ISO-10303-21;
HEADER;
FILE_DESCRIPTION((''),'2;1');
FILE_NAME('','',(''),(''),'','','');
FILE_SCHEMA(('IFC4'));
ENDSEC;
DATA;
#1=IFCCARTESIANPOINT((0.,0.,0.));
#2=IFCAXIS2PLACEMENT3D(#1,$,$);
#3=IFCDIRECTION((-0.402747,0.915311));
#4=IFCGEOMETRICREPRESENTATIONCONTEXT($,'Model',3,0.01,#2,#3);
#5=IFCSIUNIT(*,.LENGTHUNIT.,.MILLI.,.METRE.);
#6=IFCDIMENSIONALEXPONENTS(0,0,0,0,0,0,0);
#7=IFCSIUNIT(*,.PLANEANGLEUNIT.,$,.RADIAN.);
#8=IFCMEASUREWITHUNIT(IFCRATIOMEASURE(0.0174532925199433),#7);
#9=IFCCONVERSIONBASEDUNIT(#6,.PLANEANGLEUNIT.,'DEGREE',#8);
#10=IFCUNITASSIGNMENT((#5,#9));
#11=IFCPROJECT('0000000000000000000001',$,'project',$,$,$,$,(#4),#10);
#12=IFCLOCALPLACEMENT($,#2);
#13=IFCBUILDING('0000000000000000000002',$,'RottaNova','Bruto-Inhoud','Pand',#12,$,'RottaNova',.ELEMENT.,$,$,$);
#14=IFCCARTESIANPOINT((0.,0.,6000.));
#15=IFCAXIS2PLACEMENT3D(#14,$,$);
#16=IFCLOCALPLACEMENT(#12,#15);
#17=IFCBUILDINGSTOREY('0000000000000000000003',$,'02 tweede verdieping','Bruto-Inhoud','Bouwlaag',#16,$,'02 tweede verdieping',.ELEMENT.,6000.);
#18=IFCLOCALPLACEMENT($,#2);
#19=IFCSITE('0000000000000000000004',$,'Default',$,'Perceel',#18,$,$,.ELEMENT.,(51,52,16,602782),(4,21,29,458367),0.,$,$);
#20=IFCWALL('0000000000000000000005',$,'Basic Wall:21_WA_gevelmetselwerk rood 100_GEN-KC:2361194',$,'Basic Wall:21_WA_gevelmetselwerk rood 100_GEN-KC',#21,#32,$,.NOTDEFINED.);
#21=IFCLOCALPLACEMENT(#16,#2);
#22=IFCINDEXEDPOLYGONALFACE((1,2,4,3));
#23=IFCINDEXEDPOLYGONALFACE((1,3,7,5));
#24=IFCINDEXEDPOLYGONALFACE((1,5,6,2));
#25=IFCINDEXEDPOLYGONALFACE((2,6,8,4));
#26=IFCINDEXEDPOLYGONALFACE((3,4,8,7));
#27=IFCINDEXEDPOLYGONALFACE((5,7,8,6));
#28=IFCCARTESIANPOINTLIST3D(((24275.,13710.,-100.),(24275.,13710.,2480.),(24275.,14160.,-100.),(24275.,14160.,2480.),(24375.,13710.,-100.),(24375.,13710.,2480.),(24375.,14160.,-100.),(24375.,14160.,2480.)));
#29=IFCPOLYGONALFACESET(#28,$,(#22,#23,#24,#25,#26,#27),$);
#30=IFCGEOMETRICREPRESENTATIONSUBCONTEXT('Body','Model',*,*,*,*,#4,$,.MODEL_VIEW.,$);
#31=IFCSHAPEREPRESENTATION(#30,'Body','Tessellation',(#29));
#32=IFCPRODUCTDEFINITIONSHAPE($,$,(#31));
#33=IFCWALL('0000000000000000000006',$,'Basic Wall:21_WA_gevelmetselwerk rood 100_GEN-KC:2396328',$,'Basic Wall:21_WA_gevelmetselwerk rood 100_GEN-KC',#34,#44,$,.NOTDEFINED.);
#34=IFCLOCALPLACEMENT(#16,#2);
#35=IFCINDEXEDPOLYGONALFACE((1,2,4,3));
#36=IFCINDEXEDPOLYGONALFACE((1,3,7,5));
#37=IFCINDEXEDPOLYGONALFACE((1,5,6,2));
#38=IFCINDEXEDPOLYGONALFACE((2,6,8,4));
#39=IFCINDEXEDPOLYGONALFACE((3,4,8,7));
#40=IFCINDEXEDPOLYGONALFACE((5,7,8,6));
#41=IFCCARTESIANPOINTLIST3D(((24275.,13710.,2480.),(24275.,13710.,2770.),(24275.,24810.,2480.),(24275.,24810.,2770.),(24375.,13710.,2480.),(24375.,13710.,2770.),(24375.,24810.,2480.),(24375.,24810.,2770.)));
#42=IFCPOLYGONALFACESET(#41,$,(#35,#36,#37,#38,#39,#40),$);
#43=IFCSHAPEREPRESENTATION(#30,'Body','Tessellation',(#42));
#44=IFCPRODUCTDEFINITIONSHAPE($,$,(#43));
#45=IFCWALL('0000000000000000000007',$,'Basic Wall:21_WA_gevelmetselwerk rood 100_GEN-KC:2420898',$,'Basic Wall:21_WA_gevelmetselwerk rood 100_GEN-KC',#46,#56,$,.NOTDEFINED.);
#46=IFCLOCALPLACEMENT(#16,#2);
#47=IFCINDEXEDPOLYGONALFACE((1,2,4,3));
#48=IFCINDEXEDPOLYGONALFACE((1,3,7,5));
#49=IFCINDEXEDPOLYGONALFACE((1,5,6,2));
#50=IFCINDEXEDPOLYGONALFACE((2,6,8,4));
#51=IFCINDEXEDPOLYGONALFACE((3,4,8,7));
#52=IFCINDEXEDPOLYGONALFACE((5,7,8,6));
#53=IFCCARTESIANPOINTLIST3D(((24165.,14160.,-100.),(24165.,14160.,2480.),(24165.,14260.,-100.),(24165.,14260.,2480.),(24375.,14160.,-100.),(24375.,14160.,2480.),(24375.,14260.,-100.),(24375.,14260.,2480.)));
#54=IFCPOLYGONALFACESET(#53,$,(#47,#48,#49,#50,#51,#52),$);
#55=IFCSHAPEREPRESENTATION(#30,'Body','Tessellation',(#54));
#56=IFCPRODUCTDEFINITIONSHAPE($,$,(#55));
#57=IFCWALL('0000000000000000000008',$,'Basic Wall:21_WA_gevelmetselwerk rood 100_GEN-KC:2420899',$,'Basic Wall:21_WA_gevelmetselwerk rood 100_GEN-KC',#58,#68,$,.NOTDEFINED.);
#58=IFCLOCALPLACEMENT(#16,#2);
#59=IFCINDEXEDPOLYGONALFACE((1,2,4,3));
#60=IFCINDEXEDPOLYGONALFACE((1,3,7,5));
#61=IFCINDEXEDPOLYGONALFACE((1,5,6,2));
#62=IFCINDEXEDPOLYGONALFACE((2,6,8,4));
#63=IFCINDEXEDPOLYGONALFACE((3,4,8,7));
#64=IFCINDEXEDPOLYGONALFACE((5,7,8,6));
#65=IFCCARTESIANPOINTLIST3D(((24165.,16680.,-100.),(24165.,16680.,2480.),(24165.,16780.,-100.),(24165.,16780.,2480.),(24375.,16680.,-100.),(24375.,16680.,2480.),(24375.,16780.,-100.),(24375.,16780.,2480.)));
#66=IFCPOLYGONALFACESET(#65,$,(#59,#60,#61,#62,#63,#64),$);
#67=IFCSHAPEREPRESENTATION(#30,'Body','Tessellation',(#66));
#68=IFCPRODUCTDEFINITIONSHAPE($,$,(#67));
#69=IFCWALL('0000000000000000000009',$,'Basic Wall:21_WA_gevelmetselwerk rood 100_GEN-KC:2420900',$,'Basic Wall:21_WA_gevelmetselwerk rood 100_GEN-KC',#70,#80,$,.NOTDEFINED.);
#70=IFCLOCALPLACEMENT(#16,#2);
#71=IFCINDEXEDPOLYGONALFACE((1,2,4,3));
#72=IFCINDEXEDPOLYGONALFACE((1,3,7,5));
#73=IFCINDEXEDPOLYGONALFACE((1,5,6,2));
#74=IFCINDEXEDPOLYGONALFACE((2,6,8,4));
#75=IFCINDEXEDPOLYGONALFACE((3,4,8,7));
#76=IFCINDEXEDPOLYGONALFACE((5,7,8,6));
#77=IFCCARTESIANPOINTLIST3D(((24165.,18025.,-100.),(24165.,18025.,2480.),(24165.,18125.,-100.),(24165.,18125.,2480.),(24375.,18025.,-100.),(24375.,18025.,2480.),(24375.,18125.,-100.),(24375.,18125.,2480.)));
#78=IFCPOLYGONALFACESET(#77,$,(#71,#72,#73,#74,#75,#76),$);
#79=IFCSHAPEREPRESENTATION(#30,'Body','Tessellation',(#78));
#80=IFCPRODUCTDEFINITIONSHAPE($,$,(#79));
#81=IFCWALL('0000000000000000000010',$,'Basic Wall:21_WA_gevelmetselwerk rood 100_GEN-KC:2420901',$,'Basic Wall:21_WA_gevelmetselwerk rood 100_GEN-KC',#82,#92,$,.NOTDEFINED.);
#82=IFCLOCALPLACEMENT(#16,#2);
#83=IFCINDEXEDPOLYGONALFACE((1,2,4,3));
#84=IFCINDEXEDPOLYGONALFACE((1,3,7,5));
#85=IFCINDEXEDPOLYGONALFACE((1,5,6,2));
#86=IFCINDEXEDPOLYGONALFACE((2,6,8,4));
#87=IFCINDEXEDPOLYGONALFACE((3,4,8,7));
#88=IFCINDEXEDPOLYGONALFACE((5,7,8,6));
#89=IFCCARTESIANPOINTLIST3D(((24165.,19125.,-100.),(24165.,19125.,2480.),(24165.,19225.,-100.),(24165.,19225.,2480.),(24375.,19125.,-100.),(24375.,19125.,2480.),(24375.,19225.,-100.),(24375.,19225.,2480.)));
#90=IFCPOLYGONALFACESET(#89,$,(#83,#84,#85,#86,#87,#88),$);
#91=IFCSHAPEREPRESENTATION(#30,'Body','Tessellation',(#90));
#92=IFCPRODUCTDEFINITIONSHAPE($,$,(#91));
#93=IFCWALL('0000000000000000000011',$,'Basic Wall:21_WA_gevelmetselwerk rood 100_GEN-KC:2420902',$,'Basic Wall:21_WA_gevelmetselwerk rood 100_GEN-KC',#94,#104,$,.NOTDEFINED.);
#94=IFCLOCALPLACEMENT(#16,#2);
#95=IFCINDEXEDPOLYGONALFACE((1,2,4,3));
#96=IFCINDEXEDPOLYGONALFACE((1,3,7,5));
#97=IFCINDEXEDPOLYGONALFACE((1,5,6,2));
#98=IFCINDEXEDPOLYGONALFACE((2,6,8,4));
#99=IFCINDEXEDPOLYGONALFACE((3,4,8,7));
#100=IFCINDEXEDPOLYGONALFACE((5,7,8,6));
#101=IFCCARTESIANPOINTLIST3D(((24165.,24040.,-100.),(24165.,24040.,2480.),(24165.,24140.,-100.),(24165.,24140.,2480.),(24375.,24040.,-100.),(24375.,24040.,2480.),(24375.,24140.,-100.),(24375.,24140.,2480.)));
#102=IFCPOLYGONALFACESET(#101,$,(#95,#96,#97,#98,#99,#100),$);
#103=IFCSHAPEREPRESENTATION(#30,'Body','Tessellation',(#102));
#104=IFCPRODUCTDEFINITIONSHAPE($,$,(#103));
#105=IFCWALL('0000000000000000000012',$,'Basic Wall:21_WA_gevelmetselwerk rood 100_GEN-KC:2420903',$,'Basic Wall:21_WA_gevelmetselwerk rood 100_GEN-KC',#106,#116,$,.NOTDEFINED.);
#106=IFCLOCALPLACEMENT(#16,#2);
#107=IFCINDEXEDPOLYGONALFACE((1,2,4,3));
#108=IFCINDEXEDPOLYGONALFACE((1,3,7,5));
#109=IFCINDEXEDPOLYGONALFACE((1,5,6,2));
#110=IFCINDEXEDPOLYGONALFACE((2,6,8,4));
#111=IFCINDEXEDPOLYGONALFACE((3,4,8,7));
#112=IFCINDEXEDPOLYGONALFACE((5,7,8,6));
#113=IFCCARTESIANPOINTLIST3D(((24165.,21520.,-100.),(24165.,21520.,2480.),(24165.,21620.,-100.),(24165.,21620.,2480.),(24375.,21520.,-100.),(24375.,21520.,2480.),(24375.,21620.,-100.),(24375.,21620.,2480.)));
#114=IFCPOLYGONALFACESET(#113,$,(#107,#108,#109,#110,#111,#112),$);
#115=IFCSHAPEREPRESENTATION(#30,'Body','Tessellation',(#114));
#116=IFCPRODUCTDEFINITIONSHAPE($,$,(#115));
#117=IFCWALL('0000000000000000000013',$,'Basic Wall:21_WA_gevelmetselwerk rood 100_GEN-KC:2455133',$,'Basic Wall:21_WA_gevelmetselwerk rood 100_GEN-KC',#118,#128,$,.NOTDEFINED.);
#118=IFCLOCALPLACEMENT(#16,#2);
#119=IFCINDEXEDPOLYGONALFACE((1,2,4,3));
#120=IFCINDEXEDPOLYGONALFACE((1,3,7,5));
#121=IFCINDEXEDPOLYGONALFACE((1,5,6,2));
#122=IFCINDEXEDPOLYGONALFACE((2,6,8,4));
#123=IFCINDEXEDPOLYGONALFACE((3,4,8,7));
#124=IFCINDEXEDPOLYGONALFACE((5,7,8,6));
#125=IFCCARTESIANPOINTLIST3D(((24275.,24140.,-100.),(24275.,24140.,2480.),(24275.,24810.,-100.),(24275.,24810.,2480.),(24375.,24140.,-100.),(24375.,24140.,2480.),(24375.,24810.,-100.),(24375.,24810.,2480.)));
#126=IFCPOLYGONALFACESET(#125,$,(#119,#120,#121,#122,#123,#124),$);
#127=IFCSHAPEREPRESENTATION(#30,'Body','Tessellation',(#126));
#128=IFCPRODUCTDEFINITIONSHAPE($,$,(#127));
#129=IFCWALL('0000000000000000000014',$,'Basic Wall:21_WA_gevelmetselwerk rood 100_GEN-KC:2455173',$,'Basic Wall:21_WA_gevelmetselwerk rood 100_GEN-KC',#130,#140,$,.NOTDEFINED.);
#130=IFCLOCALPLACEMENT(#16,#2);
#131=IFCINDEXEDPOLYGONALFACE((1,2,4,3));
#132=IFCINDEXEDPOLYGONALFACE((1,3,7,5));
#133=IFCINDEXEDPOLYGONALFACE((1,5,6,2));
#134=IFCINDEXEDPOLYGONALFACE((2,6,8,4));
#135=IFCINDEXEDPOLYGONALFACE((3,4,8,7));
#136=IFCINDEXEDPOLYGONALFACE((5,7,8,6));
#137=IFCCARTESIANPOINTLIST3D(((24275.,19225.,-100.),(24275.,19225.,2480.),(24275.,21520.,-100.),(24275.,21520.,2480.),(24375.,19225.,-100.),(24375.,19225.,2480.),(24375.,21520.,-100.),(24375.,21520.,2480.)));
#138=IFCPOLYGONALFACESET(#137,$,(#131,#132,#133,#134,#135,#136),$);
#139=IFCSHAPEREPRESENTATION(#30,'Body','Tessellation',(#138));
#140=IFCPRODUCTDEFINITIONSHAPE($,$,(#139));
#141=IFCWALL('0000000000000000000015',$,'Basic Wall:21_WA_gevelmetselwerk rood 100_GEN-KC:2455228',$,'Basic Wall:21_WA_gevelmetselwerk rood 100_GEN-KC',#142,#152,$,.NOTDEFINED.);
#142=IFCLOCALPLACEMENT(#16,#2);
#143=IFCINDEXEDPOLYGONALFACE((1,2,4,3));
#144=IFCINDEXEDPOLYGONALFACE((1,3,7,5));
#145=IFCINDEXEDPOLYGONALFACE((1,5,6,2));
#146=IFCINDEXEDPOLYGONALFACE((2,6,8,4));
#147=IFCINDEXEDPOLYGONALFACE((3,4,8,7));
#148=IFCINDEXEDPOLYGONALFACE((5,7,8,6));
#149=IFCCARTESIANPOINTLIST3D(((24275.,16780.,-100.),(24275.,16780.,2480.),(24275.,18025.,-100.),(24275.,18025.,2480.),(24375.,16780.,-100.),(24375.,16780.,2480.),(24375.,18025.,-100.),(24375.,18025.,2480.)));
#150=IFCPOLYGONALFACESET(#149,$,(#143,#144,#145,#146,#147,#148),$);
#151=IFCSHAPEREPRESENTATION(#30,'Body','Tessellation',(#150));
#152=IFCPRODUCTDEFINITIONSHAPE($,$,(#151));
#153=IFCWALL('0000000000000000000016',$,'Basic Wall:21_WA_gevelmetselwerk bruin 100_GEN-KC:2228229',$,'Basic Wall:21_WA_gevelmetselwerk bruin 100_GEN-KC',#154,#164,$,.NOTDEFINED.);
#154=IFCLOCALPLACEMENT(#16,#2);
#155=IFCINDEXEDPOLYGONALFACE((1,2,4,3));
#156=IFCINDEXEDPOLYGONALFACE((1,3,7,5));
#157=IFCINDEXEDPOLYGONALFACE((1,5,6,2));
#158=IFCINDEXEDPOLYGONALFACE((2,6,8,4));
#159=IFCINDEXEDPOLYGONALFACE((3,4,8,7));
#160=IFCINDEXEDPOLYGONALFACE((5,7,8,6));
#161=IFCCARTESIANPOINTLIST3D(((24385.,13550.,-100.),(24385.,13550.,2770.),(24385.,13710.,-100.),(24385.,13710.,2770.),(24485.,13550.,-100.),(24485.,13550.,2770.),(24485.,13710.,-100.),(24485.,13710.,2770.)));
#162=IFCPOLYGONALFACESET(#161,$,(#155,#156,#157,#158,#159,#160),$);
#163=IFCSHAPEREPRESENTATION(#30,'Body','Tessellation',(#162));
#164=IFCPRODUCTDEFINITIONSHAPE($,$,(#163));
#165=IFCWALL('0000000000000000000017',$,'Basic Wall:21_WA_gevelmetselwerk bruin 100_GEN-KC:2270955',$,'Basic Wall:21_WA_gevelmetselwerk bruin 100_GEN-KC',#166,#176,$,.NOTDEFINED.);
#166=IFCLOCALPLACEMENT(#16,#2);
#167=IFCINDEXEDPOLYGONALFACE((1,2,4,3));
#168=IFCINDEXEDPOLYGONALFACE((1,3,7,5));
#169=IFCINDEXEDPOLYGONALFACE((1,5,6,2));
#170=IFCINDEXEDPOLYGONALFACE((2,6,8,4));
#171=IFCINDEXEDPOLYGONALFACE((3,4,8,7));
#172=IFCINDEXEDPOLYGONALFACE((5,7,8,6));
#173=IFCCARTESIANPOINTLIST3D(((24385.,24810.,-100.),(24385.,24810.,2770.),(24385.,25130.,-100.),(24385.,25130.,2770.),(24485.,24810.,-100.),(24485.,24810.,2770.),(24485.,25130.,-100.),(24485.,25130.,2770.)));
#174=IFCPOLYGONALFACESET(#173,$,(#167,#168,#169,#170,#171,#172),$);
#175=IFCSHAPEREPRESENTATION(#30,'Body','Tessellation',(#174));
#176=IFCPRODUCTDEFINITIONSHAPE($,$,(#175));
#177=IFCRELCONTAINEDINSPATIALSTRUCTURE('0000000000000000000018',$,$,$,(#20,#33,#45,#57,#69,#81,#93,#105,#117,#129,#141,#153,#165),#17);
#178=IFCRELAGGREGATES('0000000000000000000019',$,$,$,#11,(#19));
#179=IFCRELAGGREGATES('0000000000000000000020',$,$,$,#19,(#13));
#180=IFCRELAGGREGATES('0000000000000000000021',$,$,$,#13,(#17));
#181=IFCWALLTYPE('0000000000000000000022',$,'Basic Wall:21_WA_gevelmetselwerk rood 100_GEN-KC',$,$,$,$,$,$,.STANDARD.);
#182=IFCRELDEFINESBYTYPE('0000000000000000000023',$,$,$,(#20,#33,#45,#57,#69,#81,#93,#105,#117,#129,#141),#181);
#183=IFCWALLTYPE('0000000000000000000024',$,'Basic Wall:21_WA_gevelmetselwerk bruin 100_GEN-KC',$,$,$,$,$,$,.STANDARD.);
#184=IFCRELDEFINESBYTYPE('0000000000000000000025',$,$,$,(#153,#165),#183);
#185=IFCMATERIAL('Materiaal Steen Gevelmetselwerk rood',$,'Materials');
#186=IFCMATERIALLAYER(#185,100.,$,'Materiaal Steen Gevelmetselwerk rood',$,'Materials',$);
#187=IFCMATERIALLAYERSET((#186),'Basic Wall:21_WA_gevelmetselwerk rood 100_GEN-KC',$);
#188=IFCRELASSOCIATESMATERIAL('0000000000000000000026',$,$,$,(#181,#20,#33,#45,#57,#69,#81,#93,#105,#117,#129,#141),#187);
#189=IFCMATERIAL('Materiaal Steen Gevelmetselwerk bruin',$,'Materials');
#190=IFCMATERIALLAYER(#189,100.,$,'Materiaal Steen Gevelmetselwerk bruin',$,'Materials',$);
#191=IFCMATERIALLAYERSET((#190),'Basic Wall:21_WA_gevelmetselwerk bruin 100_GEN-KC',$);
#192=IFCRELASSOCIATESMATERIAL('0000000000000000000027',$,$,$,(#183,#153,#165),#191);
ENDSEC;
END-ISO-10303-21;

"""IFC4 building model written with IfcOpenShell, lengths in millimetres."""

from ifc_helpers import new_model, entity, si_unit, converted_unit, direction, frame, frame_2d, origin, place, context, subcontext, project, spatial, rectangle, extrude, material, layer, layer_set, type_object, element, save


model = new_model("IFC4")

# Units and contexts
model_context = context("Model", 3, precision=0.01, world=origin(), true_north=direction((-0.402747, 0.915311)))
body_context = subcontext(model_context, "Body", "Model", "MODEL_VIEW")
ifc_project = project(units=[si_unit("LENGTHUNIT", "METRE", prefix="MILLI"), converted_unit("PLANEANGLEUNIT", "DEGREE", entity("IfcRatioMeasure", 0.0174532925199433), si_unit("PLANEANGLEUNIT", "RADIAN"), dimensions=[0, 0, 0, 0, 0, 0, 0])], contexts=[model_context])

# Site, building, storey
site_placement = place(None, origin())
site = spatial("IfcSite", under=ifc_project, at=site_placement, Name="Default", ObjectType="Perceel", CompositionType="ELEMENT", RefLatitude=(51, 52, 16, 602782), RefLongitude=(4, 21, 29, 458367), RefElevation=0.0)
building_placement = place(None, origin())
building = spatial("IfcBuilding", under=site, at=building_placement, Name="RottaNova", Description="Bruto-Inhoud", ObjectType="Pand", LongName="RottaNova", CompositionType="ELEMENT")
storey_placement = place(building_placement, frame((0.0, 0.0, 6000.0)))
storey = spatial("IfcBuildingStorey", under=building, at=storey_placement, Name="02 tweede verdieping", Description="Bruto-Inhoud", ObjectType="Bouwlaag", LongName="02 tweede verdieping", CompositionType="ELEMENT", Elevation=6000.0)

# Walls
ifc_material_1 = material(Name="Materiaal Steen Gevelmetselwerk rood", Category="Materials")
ifc_layer_1 = layer(ifc_material_1, 100.0, Name="Materiaal Steen Gevelmetselwerk rood", Category="Materials")
ifc_layer_set_1 = layer_set([ifc_layer_1], Name="Basic Wall:21_WA_gevelmetselwerk rood 100_GEN-KC")
wall_type_1 = type_object("IfcWallType", Name="Basic Wall:21_WA_gevelmetselwerk rood 100_GEN-KC", PredefinedType="STANDARD", material=ifc_layer_set_1)
wall_1_placement = place(storey_placement, frame((24325.0, 13710.0, -100.0), z_axis=(0.0, 0.0, 1.0), x_axis=(0.0, 1.0, 0.0)))
element("IfcWall", 1, at=wall_1_placement, inside=storey, type_object=wall_type_1, material=ifc_layer_set_1, Name="Basic Wall:21_WA_gevelmetselwerk rood 100_GEN-KC:2361194", ObjectType="Basic Wall:21_WA_gevelmetselwerk rood 100_GEN-KC", PredefinedType="NOTDEFINED", context=body_context, shape_type="SweptSolid", body=[
    extrude(rectangle(XDim=450.0, YDim=100.0, at=frame_2d((225.0, 0.0), x_axis=(-1.0, 0.0))), origin(), (0.0, 0.0, 1.0), 2580.0),
])
wall_2_placement = place(storey_placement, frame((24325.0, 13710.0, 2480.0), z_axis=(0.0, 0.0, 1.0), x_axis=(0.0, 1.0, 0.0)))
element("IfcWall", 2, at=wall_2_placement, inside=storey, type_object=wall_type_1, material=ifc_layer_set_1, Name="Basic Wall:21_WA_gevelmetselwerk rood 100_GEN-KC:2396328", ObjectType="Basic Wall:21_WA_gevelmetselwerk rood 100_GEN-KC", PredefinedType="NOTDEFINED", context=body_context, shape_type="SweptSolid", body=[
    extrude(rectangle(XDim=11100.0, YDim=100.0, at=frame_2d((5550.0, 0.0), x_axis=(-1.0, 0.0))), origin(), (0.0, 0.0, 1.0), 290.0),
])
wall_3_placement = place(storey_placement, frame((24375.0, 14210.0, -100.0), z_axis=(0.0, 0.0, 1.0), x_axis=(-1.0, 0.0, 0.0)))
element("IfcWall", 3, at=wall_3_placement, inside=storey, type_object=wall_type_1, material=ifc_layer_set_1, Name="Basic Wall:21_WA_gevelmetselwerk rood 100_GEN-KC:2420898", ObjectType="Basic Wall:21_WA_gevelmetselwerk rood 100_GEN-KC", PredefinedType="NOTDEFINED", context=body_context, shape_type="SweptSolid", body=[
    extrude(rectangle(XDim=210.0, YDim=100.0, at=frame_2d((105.0, 0.0), x_axis=(-1.0, 0.0))), origin(), (0.0, 0.0, 1.0), 2580.0),
])
wall_4_placement = place(storey_placement, frame((24375.0, 16730.0, -100.0), z_axis=(0.0, 0.0, 1.0), x_axis=(-1.0, 0.0, 0.0)))
element("IfcWall", 4, at=wall_4_placement, inside=storey, type_object=wall_type_1, material=ifc_layer_set_1, Name="Basic Wall:21_WA_gevelmetselwerk rood 100_GEN-KC:2420899", ObjectType="Basic Wall:21_WA_gevelmetselwerk rood 100_GEN-KC", PredefinedType="NOTDEFINED", context=body_context, shape_type="SweptSolid", body=[
    extrude(rectangle(XDim=210.0, YDim=100.0, at=frame_2d((105.0, 0.0), x_axis=(-1.0, 0.0))), origin(), (0.0, 0.0, 1.0), 2580.0),
])
wall_5_placement = place(storey_placement, frame((24375.0, 18075.0, -100.0), z_axis=(0.0, 0.0, 1.0), x_axis=(-1.0, 0.0, 0.0)))
element("IfcWall", 5, at=wall_5_placement, inside=storey, type_object=wall_type_1, material=ifc_layer_set_1, Name="Basic Wall:21_WA_gevelmetselwerk rood 100_GEN-KC:2420900", ObjectType="Basic Wall:21_WA_gevelmetselwerk rood 100_GEN-KC", PredefinedType="NOTDEFINED", context=body_context, shape_type="SweptSolid", body=[
    extrude(rectangle(XDim=210.0, YDim=100.0, at=frame_2d((105.0, 0.0), x_axis=(-1.0, 0.0))), origin(), (0.0, 0.0, 1.0), 2580.0),
])
wall_6_placement = place(storey_placement, frame((24375.0, 19175.0, -100.0), z_axis=(0.0, 0.0, 1.0), x_axis=(-1.0, 0.0, 0.0)))
element("IfcWall", 6, at=wall_6_placement, inside=storey, type_object=wall_type_1, material=ifc_layer_set_1, Name="Basic Wall:21_WA_gevelmetselwerk rood 100_GEN-KC:2420901", ObjectType="Basic Wall:21_WA_gevelmetselwerk rood 100_GEN-KC", PredefinedType="NOTDEFINED", context=body_context, shape_type="SweptSolid", body=[
    extrude(rectangle(XDim=210.0, YDim=100.0, at=frame_2d((105.0, 0.0), x_axis=(-1.0, 0.0))), origin(), (0.0, 0.0, 1.0), 2580.0),
])
wall_7_placement = place(storey_placement, frame((24375.0, 24090.0, -100.0), z_axis=(0.0, 0.0, 1.0), x_axis=(-1.0, 0.0, 0.0)))
element("IfcWall", 7, at=wall_7_placement, inside=storey, type_object=wall_type_1, material=ifc_layer_set_1, Name="Basic Wall:21_WA_gevelmetselwerk rood 100_GEN-KC:2420902", ObjectType="Basic Wall:21_WA_gevelmetselwerk rood 100_GEN-KC", PredefinedType="NOTDEFINED", context=body_context, shape_type="SweptSolid", body=[
    extrude(rectangle(XDim=210.0, YDim=100.0, at=frame_2d((105.0, 0.0), x_axis=(-1.0, 0.0))), origin(), (0.0, 0.0, 1.0), 2580.0),
])
wall_8_placement = place(storey_placement, frame((24375.0, 21570.0, -100.0), z_axis=(0.0, 0.0, 1.0), x_axis=(-1.0, 0.0, 0.0)))
element("IfcWall", 8, at=wall_8_placement, inside=storey, type_object=wall_type_1, material=ifc_layer_set_1, Name="Basic Wall:21_WA_gevelmetselwerk rood 100_GEN-KC:2420903", ObjectType="Basic Wall:21_WA_gevelmetselwerk rood 100_GEN-KC", PredefinedType="NOTDEFINED", context=body_context, shape_type="SweptSolid", body=[
    extrude(rectangle(XDim=210.0, YDim=100.0, at=frame_2d((105.0, 0.0), x_axis=(-1.0, 0.0))), origin(), (0.0, 0.0, 1.0), 2580.0),
])
wall_9_placement = place(storey_placement, frame((24325.0, 24140.0, -100.0), z_axis=(0.0, 0.0, 1.0), x_axis=(0.0, 1.0, 0.0)))
element("IfcWall", 9, at=wall_9_placement, inside=storey, type_object=wall_type_1, material=ifc_layer_set_1, Name="Basic Wall:21_WA_gevelmetselwerk rood 100_GEN-KC:2455133", ObjectType="Basic Wall:21_WA_gevelmetselwerk rood 100_GEN-KC", PredefinedType="NOTDEFINED", context=body_context, shape_type="SweptSolid", body=[
    extrude(rectangle(XDim=670.0, YDim=100.0, at=frame_2d((335.0, 0.0), x_axis=(-1.0, 0.0))), origin(), (0.0, 0.0, 1.0), 2580.0),
])
wall_10_placement = place(storey_placement, frame((24325.0, 19225.0, -100.0), z_axis=(0.0, 0.0, 1.0), x_axis=(0.0, 1.0, 0.0)))
element("IfcWall", 10, at=wall_10_placement, inside=storey, type_object=wall_type_1, material=ifc_layer_set_1, Name="Basic Wall:21_WA_gevelmetselwerk rood 100_GEN-KC:2455173", ObjectType="Basic Wall:21_WA_gevelmetselwerk rood 100_GEN-KC", PredefinedType="NOTDEFINED", context=body_context, shape_type="SweptSolid", body=[
    extrude(rectangle(XDim=2295.0, YDim=100.0, at=frame_2d((1147.5, 0.0), x_axis=(-1.0, 0.0))), origin(), (0.0, 0.0, 1.0), 2580.0),
])
wall_11_placement = place(storey_placement, frame((24325.0, 16780.0, -100.0), z_axis=(0.0, 0.0, 1.0), x_axis=(0.0, 1.0, 0.0)))
element("IfcWall", 11, at=wall_11_placement, inside=storey, type_object=wall_type_1, material=ifc_layer_set_1, Name="Basic Wall:21_WA_gevelmetselwerk rood 100_GEN-KC:2455228", ObjectType="Basic Wall:21_WA_gevelmetselwerk rood 100_GEN-KC", PredefinedType="NOTDEFINED", context=body_context, shape_type="SweptSolid", body=[
    extrude(rectangle(XDim=1245.0, YDim=100.0, at=frame_2d((622.5, 0.0), x_axis=(-1.0, 0.0))), origin(), (0.0, 0.0, 1.0), 2580.0),
])
ifc_material_2 = material(Name="Materiaal Steen Gevelmetselwerk bruin", Category="Materials")
ifc_layer_2 = layer(ifc_material_2, 100.0, Name="Materiaal Steen Gevelmetselwerk bruin", Category="Materials")
ifc_layer_set_2 = layer_set([ifc_layer_2], Name="Basic Wall:21_WA_gevelmetselwerk bruin 100_GEN-KC")
wall_type_2 = type_object("IfcWallType", Name="Basic Wall:21_WA_gevelmetselwerk bruin 100_GEN-KC", PredefinedType="STANDARD", material=ifc_layer_set_2)
wall_12_placement = place(storey_placement, frame((24435.0, 13710.0, -100.0), z_axis=(0.0, 0.0, 1.0), x_axis=(0.0, -1.0, 0.0)))
element("IfcWall", 12, at=wall_12_placement, inside=storey, type_object=wall_type_2, material=ifc_layer_set_2, Name="Basic Wall:21_WA_gevelmetselwerk bruin 100_GEN-KC:2228229", ObjectType="Basic Wall:21_WA_gevelmetselwerk bruin 100_GEN-KC", PredefinedType="NOTDEFINED", context=body_context, shape_type="SweptSolid", body=[
    extrude(rectangle(XDim=160.0, YDim=100.0, at=frame_2d((80.0, 0.0), x_axis=(-1.0, 0.0))), origin(), (0.0, 0.0, 1.0), 2870.0),
])
wall_13_placement = place(storey_placement, frame((24435.0, 25130.0, -100.0), z_axis=(0.0, 0.0, 1.0), x_axis=(0.0, -1.0, 0.0)))
element("IfcWall", 13, at=wall_13_placement, inside=storey, type_object=wall_type_2, material=ifc_layer_set_2, Name="Basic Wall:21_WA_gevelmetselwerk bruin 100_GEN-KC:2270955", ObjectType="Basic Wall:21_WA_gevelmetselwerk bruin 100_GEN-KC", PredefinedType="NOTDEFINED", context=body_context, shape_type="SweptSolid", body=[
    extrude(rectangle(XDim=320.0, YDim=100.0, at=frame_2d((160.0, 0.0), x_axis=(-1.0, 0.0))), origin(), (0.0, 0.0, 1.0), 2870.0),
])

save(model, "model.ifc")
